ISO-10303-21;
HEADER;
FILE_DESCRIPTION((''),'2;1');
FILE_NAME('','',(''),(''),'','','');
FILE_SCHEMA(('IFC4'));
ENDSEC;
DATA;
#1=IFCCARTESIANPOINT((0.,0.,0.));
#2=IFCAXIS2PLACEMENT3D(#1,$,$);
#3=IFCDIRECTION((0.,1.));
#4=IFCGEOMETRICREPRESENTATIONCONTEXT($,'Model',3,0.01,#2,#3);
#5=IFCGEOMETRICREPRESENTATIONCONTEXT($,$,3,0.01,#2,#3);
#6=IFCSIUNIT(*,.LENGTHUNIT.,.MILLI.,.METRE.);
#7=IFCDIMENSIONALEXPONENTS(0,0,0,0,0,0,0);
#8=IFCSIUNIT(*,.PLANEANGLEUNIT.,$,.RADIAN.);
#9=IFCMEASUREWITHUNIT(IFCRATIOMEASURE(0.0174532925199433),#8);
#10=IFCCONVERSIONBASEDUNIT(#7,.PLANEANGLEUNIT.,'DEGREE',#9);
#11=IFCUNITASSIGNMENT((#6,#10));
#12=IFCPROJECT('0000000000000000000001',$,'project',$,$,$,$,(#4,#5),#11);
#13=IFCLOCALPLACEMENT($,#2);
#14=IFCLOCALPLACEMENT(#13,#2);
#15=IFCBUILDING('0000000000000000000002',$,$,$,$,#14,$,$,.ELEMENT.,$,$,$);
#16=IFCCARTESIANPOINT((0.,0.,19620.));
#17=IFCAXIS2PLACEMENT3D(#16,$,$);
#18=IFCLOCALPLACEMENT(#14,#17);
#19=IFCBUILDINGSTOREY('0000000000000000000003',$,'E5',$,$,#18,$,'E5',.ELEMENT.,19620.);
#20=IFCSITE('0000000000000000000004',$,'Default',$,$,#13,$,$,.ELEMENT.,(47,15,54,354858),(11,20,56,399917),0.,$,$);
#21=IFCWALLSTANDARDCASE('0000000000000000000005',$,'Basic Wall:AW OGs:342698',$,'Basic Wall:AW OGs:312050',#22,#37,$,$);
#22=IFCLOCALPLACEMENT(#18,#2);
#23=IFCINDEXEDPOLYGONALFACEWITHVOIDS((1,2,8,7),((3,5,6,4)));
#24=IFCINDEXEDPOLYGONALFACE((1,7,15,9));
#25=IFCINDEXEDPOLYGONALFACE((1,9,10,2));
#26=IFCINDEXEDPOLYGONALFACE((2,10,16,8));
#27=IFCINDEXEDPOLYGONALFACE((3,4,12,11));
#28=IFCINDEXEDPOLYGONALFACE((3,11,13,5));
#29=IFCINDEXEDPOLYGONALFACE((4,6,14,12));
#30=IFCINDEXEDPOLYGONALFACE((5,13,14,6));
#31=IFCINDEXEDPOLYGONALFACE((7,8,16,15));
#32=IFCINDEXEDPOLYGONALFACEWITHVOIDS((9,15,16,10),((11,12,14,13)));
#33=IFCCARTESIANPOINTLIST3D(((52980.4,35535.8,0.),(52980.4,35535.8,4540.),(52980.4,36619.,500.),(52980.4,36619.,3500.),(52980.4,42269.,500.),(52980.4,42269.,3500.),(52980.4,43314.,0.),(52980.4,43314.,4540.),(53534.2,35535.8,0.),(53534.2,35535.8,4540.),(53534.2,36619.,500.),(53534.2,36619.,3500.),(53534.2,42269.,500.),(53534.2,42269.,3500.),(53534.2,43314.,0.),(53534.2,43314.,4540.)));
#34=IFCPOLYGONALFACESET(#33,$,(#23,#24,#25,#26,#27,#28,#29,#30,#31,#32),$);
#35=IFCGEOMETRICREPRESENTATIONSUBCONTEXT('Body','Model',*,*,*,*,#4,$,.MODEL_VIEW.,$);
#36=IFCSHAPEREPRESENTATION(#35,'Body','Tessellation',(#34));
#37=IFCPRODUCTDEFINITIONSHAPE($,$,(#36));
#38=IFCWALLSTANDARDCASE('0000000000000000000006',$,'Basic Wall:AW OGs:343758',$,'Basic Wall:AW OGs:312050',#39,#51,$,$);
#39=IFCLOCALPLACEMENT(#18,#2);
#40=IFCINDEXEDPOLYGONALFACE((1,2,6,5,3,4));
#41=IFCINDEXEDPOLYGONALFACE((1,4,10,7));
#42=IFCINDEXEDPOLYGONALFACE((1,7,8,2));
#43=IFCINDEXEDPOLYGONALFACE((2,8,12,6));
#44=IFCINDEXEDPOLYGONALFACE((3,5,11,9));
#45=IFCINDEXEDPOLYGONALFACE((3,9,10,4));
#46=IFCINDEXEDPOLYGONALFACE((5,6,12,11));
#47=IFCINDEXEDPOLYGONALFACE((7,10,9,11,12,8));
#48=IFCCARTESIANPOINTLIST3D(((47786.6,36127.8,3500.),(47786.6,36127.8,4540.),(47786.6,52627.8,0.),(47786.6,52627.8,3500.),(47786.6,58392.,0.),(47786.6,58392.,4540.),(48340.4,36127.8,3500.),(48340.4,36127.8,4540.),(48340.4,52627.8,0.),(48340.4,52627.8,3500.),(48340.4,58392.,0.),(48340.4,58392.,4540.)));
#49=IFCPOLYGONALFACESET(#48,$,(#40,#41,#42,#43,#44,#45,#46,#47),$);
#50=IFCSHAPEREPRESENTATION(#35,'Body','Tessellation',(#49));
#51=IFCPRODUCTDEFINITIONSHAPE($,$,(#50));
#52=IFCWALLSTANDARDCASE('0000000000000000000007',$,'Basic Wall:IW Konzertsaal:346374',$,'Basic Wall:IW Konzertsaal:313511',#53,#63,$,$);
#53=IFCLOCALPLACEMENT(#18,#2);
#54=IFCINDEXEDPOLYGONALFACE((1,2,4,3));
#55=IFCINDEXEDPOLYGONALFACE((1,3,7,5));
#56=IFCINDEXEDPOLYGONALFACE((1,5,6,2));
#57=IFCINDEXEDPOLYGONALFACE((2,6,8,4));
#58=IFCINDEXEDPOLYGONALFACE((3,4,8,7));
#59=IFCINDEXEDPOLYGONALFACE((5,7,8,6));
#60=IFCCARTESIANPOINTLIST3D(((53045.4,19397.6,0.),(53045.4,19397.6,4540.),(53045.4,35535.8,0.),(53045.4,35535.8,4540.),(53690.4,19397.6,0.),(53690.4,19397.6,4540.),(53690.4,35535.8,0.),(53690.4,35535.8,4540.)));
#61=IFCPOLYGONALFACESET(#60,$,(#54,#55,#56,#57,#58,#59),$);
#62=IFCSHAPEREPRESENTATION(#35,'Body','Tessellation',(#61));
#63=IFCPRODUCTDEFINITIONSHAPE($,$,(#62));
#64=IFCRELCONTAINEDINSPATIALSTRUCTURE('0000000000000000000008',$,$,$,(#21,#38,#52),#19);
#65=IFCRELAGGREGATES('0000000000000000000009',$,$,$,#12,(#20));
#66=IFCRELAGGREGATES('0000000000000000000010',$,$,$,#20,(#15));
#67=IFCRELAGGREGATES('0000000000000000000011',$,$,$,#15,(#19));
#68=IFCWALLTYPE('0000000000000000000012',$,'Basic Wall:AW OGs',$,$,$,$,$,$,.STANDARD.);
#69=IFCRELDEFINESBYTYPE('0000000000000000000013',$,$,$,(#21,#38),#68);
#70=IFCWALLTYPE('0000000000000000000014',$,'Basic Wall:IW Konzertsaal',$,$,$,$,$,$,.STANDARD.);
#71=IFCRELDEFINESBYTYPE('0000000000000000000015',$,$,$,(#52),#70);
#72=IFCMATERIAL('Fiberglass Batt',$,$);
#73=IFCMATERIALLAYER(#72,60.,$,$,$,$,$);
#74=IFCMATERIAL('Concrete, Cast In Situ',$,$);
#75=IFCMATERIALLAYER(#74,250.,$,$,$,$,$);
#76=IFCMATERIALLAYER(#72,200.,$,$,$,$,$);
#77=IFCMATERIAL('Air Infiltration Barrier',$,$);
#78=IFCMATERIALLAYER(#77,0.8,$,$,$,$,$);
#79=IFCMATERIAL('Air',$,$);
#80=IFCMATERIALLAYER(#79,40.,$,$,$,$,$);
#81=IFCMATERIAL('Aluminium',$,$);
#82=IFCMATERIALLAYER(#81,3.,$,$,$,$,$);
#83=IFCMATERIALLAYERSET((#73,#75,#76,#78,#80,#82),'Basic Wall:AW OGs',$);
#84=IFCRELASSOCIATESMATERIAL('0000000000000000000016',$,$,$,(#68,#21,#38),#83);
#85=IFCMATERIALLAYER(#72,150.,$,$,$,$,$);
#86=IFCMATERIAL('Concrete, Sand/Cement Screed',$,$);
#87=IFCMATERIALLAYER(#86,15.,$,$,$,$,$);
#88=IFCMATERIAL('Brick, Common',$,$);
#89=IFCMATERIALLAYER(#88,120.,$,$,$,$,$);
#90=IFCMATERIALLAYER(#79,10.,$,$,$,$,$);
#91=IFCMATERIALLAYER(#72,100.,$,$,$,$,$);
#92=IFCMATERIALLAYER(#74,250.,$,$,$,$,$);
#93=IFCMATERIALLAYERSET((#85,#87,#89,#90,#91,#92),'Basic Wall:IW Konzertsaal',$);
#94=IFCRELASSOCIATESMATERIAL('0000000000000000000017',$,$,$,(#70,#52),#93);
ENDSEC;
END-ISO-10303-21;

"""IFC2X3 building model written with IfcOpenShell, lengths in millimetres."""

from ifc_helpers import new_model, entity, si_unit, converted_unit, direction, frame, frame_2d, origin, place, context, subcontext, project, spatial, rectangle, extrude, material, layer, layer_set, layer_usage, type_object, element, save


model = new_model("IFC2X3")

# Units and contexts
model_context = context("Model", 3, precision=0.01, world=origin(), true_north=direction((0.0, 1.0)))
context_of_model = context(None, 3, precision=0.01, world=origin(), true_north=direction((0.0, 1.0)))
body_context = subcontext(model_context, "Body", "Model", "MODEL_VIEW")
ifc_project = project(units=[si_unit("LENGTHUNIT", "METRE", prefix="MILLI"), converted_unit("PLANEANGLEUNIT", "DEGREE", entity("IfcRatioMeasure", 0.0174532925199433), si_unit("PLANEANGLEUNIT", "RADIAN"), dimensions=[0, 0, 0, 0, 0, 0, 0])], contexts=[model_context, context_of_model])

# Site, building, storey
site_placement = place(None, origin())
site = spatial("IfcSite", under=ifc_project, at=site_placement, Name="Default", CompositionType="ELEMENT", RefLatitude=(47, 15, 54, 354858), RefLongitude=(11, 20, 56, 399917), RefElevation=0.0)
building_placement = place(site_placement, origin())
building = spatial("IfcBuilding", under=site, at=building_placement, CompositionType="ELEMENT")
storey_placement = place(building_placement, frame((0.0, 0.0, 19620.0)))
storey = spatial("IfcBuildingStorey", under=building, at=storey_placement, Name="E5", LongName="E5", CompositionType="ELEMENT", Elevation=19620.0)

# Shared definitions
ifc_material_1 = material(Name="Concrete, Sand/Cement Screed")
ifc_material_2 = material(Name="Air Infiltration Barrier")
ifc_material_3 = material(Name="Fiberglass Batt")

# Shared definitions
ifc_material_4 = material(Name="Concrete, Cast In Situ")

# Shared definitions
ifc_layer_1 = layer(ifc_material_3, 60.0)
ifc_layer_2 = layer(ifc_material_4, 250.0)
ifc_layer_3 = layer(ifc_material_3, 200.0)
ifc_layer_4 = layer(ifc_material_2, 0.8)
ifc_material_5 = material(Name="Air")
ifc_layer_5 = layer(ifc_material_5, 40.0)
ifc_material_6 = material(Name="Aluminium")
ifc_layer_6 = layer(ifc_material_6, 3.0)
ifc_layer_set_1 = layer_set([ifc_layer_1, ifc_layer_2, ifc_layer_3, ifc_layer_4, ifc_layer_5, ifc_layer_6], Name="Basic Wall:AW OGs")
wall_type_1 = type_object("IfcWallType", Name="Basic Wall:AW OGs", PredefinedType="STANDARD", material=ifc_layer_set_1)

# Walls, openings
ifc_layer_usage_1 = layer_usage(ifc_layer_set_1, "AXIS2", "NEGATIVE", 276.9)
wall_1_placement = place(storey_placement, frame((53257.3, 35535.8, 0.0), z_axis=(0.0, 0.0, 1.0), x_axis=(0.0, 1.0, 0.0)))
wall_1 = element("IfcWallStandardCase", 1, at=wall_1_placement, inside=storey, type_object=wall_type_1, material=ifc_layer_usage_1, Name="Basic Wall:AW OGs:342698", ObjectType="Basic Wall:AW OGs:312050", context=body_context, shape_type="SweptSolid", body=[
    extrude(rectangle(XDim=7778.2, YDim=553.8, at=frame_2d((3889.1, 0.0), x_axis=(-1.0, 0.0))), origin(), (0.0, 0.0, 1.0), 4540.0),
])
opening_1_placement = place(wall_1_placement, frame((6733.2, 276.9, 500.0)))
element("IfcOpeningElement", 2, at=opening_1_placement, cuts=wall_1, ObjectType="Opening", context=body_context, shape_type="SweptSolid", body=[
    extrude(rectangle(XDim=3000.0, YDim=5650.0, at=frame_2d((1500.0, 2825.0), x_axis=(-1.0, 0.0))), frame((0.0, 0.0, 0.0), z_axis=(0.0, -1.0, 0.0), x_axis=(0.0, 0.0, 1.0)), (0.0, 0.0, 1.0), 553.8),
])
ifc_layer_usage_2 = layer_usage(ifc_layer_set_1, "AXIS2", "NEGATIVE", 276.9)
wall_2_placement = place(storey_placement, frame((48063.5, 58392.0, 0.0), z_axis=(0.0, 0.0, 1.0), x_axis=(0.0, -1.0, 0.0)))
wall_2 = element("IfcWallStandardCase", 3, at=wall_2_placement, inside=storey, type_object=wall_type_1, material=ifc_layer_usage_2, Name="Basic Wall:AW OGs:343758", ObjectType="Basic Wall:AW OGs:312050", context=body_context, shape_type="SweptSolid", body=[
    extrude(rectangle(XDim=22264.3, YDim=553.8, at=frame_2d((11132.1, 0.0), x_axis=(-1.0, 0.0))), origin(), (0.0, 0.0, 1.0), 4540.0),
])
opening_2_placement = place(wall_2_placement, frame((22264.3, 276.9, 0.0)))
element("IfcOpeningElement", 4, at=opening_2_placement, cuts=wall_2, ObjectType="Opening", context=body_context, shape_type="SweptSolid", body=[
    extrude(rectangle(XDim=3500.0, YDim=16500.0, at=frame_2d((1750.0, 8250.0), x_axis=(-1.0, 0.0))), frame((0.0, 0.0, 0.0), z_axis=(0.0, -1.0, 0.0), x_axis=(0.0, 0.0, 1.0)), (0.0, 0.0, 1.0), 553.8),
])

# Wall
ifc_layer_7 = layer(ifc_material_3, 150.0)
ifc_layer_8 = layer(ifc_material_1, 15.0)
ifc_material_7 = material(Name="Brick, Common")
ifc_layer_9 = layer(ifc_material_7, 120.0)
ifc_layer_10 = layer(ifc_material_5, 10.0)
ifc_layer_11 = layer(ifc_material_3, 100.0)
ifc_layer_12 = layer(ifc_material_4, 250.0)
ifc_layer_set_2 = layer_set([ifc_layer_7, ifc_layer_8, ifc_layer_9, ifc_layer_10, ifc_layer_11, ifc_layer_12], Name="Basic Wall:IW Konzertsaal")
ifc_layer_usage_3 = layer_usage(ifc_layer_set_2, "AXIS2", "NEGATIVE", 322.5)
wall_type_2 = type_object("IfcWallType", Name="Basic Wall:IW Konzertsaal", PredefinedType="STANDARD", material=ifc_layer_set_2)
wall_3_placement = place(storey_placement, frame((53367.9, 35535.8, 0.0), z_axis=(0.0, 0.0, 1.0), x_axis=(0.0, -1.0, 0.0)))
element("IfcWallStandardCase", 5, at=wall_3_placement, inside=storey, type_object=wall_type_2, material=ifc_layer_usage_3, Name="Basic Wall:IW Konzertsaal:346374", ObjectType="Basic Wall:IW Konzertsaal:313511", context=body_context, shape_type="SweptSolid", body=[
    extrude(rectangle(XDim=16138.2, YDim=645.0, at=frame_2d((8069.1, 0.0), x_axis=(-1.0, 0.0))), origin(), (0.0, 0.0, 1.0), 4540.0),
])

save(model, "model.ifc")
